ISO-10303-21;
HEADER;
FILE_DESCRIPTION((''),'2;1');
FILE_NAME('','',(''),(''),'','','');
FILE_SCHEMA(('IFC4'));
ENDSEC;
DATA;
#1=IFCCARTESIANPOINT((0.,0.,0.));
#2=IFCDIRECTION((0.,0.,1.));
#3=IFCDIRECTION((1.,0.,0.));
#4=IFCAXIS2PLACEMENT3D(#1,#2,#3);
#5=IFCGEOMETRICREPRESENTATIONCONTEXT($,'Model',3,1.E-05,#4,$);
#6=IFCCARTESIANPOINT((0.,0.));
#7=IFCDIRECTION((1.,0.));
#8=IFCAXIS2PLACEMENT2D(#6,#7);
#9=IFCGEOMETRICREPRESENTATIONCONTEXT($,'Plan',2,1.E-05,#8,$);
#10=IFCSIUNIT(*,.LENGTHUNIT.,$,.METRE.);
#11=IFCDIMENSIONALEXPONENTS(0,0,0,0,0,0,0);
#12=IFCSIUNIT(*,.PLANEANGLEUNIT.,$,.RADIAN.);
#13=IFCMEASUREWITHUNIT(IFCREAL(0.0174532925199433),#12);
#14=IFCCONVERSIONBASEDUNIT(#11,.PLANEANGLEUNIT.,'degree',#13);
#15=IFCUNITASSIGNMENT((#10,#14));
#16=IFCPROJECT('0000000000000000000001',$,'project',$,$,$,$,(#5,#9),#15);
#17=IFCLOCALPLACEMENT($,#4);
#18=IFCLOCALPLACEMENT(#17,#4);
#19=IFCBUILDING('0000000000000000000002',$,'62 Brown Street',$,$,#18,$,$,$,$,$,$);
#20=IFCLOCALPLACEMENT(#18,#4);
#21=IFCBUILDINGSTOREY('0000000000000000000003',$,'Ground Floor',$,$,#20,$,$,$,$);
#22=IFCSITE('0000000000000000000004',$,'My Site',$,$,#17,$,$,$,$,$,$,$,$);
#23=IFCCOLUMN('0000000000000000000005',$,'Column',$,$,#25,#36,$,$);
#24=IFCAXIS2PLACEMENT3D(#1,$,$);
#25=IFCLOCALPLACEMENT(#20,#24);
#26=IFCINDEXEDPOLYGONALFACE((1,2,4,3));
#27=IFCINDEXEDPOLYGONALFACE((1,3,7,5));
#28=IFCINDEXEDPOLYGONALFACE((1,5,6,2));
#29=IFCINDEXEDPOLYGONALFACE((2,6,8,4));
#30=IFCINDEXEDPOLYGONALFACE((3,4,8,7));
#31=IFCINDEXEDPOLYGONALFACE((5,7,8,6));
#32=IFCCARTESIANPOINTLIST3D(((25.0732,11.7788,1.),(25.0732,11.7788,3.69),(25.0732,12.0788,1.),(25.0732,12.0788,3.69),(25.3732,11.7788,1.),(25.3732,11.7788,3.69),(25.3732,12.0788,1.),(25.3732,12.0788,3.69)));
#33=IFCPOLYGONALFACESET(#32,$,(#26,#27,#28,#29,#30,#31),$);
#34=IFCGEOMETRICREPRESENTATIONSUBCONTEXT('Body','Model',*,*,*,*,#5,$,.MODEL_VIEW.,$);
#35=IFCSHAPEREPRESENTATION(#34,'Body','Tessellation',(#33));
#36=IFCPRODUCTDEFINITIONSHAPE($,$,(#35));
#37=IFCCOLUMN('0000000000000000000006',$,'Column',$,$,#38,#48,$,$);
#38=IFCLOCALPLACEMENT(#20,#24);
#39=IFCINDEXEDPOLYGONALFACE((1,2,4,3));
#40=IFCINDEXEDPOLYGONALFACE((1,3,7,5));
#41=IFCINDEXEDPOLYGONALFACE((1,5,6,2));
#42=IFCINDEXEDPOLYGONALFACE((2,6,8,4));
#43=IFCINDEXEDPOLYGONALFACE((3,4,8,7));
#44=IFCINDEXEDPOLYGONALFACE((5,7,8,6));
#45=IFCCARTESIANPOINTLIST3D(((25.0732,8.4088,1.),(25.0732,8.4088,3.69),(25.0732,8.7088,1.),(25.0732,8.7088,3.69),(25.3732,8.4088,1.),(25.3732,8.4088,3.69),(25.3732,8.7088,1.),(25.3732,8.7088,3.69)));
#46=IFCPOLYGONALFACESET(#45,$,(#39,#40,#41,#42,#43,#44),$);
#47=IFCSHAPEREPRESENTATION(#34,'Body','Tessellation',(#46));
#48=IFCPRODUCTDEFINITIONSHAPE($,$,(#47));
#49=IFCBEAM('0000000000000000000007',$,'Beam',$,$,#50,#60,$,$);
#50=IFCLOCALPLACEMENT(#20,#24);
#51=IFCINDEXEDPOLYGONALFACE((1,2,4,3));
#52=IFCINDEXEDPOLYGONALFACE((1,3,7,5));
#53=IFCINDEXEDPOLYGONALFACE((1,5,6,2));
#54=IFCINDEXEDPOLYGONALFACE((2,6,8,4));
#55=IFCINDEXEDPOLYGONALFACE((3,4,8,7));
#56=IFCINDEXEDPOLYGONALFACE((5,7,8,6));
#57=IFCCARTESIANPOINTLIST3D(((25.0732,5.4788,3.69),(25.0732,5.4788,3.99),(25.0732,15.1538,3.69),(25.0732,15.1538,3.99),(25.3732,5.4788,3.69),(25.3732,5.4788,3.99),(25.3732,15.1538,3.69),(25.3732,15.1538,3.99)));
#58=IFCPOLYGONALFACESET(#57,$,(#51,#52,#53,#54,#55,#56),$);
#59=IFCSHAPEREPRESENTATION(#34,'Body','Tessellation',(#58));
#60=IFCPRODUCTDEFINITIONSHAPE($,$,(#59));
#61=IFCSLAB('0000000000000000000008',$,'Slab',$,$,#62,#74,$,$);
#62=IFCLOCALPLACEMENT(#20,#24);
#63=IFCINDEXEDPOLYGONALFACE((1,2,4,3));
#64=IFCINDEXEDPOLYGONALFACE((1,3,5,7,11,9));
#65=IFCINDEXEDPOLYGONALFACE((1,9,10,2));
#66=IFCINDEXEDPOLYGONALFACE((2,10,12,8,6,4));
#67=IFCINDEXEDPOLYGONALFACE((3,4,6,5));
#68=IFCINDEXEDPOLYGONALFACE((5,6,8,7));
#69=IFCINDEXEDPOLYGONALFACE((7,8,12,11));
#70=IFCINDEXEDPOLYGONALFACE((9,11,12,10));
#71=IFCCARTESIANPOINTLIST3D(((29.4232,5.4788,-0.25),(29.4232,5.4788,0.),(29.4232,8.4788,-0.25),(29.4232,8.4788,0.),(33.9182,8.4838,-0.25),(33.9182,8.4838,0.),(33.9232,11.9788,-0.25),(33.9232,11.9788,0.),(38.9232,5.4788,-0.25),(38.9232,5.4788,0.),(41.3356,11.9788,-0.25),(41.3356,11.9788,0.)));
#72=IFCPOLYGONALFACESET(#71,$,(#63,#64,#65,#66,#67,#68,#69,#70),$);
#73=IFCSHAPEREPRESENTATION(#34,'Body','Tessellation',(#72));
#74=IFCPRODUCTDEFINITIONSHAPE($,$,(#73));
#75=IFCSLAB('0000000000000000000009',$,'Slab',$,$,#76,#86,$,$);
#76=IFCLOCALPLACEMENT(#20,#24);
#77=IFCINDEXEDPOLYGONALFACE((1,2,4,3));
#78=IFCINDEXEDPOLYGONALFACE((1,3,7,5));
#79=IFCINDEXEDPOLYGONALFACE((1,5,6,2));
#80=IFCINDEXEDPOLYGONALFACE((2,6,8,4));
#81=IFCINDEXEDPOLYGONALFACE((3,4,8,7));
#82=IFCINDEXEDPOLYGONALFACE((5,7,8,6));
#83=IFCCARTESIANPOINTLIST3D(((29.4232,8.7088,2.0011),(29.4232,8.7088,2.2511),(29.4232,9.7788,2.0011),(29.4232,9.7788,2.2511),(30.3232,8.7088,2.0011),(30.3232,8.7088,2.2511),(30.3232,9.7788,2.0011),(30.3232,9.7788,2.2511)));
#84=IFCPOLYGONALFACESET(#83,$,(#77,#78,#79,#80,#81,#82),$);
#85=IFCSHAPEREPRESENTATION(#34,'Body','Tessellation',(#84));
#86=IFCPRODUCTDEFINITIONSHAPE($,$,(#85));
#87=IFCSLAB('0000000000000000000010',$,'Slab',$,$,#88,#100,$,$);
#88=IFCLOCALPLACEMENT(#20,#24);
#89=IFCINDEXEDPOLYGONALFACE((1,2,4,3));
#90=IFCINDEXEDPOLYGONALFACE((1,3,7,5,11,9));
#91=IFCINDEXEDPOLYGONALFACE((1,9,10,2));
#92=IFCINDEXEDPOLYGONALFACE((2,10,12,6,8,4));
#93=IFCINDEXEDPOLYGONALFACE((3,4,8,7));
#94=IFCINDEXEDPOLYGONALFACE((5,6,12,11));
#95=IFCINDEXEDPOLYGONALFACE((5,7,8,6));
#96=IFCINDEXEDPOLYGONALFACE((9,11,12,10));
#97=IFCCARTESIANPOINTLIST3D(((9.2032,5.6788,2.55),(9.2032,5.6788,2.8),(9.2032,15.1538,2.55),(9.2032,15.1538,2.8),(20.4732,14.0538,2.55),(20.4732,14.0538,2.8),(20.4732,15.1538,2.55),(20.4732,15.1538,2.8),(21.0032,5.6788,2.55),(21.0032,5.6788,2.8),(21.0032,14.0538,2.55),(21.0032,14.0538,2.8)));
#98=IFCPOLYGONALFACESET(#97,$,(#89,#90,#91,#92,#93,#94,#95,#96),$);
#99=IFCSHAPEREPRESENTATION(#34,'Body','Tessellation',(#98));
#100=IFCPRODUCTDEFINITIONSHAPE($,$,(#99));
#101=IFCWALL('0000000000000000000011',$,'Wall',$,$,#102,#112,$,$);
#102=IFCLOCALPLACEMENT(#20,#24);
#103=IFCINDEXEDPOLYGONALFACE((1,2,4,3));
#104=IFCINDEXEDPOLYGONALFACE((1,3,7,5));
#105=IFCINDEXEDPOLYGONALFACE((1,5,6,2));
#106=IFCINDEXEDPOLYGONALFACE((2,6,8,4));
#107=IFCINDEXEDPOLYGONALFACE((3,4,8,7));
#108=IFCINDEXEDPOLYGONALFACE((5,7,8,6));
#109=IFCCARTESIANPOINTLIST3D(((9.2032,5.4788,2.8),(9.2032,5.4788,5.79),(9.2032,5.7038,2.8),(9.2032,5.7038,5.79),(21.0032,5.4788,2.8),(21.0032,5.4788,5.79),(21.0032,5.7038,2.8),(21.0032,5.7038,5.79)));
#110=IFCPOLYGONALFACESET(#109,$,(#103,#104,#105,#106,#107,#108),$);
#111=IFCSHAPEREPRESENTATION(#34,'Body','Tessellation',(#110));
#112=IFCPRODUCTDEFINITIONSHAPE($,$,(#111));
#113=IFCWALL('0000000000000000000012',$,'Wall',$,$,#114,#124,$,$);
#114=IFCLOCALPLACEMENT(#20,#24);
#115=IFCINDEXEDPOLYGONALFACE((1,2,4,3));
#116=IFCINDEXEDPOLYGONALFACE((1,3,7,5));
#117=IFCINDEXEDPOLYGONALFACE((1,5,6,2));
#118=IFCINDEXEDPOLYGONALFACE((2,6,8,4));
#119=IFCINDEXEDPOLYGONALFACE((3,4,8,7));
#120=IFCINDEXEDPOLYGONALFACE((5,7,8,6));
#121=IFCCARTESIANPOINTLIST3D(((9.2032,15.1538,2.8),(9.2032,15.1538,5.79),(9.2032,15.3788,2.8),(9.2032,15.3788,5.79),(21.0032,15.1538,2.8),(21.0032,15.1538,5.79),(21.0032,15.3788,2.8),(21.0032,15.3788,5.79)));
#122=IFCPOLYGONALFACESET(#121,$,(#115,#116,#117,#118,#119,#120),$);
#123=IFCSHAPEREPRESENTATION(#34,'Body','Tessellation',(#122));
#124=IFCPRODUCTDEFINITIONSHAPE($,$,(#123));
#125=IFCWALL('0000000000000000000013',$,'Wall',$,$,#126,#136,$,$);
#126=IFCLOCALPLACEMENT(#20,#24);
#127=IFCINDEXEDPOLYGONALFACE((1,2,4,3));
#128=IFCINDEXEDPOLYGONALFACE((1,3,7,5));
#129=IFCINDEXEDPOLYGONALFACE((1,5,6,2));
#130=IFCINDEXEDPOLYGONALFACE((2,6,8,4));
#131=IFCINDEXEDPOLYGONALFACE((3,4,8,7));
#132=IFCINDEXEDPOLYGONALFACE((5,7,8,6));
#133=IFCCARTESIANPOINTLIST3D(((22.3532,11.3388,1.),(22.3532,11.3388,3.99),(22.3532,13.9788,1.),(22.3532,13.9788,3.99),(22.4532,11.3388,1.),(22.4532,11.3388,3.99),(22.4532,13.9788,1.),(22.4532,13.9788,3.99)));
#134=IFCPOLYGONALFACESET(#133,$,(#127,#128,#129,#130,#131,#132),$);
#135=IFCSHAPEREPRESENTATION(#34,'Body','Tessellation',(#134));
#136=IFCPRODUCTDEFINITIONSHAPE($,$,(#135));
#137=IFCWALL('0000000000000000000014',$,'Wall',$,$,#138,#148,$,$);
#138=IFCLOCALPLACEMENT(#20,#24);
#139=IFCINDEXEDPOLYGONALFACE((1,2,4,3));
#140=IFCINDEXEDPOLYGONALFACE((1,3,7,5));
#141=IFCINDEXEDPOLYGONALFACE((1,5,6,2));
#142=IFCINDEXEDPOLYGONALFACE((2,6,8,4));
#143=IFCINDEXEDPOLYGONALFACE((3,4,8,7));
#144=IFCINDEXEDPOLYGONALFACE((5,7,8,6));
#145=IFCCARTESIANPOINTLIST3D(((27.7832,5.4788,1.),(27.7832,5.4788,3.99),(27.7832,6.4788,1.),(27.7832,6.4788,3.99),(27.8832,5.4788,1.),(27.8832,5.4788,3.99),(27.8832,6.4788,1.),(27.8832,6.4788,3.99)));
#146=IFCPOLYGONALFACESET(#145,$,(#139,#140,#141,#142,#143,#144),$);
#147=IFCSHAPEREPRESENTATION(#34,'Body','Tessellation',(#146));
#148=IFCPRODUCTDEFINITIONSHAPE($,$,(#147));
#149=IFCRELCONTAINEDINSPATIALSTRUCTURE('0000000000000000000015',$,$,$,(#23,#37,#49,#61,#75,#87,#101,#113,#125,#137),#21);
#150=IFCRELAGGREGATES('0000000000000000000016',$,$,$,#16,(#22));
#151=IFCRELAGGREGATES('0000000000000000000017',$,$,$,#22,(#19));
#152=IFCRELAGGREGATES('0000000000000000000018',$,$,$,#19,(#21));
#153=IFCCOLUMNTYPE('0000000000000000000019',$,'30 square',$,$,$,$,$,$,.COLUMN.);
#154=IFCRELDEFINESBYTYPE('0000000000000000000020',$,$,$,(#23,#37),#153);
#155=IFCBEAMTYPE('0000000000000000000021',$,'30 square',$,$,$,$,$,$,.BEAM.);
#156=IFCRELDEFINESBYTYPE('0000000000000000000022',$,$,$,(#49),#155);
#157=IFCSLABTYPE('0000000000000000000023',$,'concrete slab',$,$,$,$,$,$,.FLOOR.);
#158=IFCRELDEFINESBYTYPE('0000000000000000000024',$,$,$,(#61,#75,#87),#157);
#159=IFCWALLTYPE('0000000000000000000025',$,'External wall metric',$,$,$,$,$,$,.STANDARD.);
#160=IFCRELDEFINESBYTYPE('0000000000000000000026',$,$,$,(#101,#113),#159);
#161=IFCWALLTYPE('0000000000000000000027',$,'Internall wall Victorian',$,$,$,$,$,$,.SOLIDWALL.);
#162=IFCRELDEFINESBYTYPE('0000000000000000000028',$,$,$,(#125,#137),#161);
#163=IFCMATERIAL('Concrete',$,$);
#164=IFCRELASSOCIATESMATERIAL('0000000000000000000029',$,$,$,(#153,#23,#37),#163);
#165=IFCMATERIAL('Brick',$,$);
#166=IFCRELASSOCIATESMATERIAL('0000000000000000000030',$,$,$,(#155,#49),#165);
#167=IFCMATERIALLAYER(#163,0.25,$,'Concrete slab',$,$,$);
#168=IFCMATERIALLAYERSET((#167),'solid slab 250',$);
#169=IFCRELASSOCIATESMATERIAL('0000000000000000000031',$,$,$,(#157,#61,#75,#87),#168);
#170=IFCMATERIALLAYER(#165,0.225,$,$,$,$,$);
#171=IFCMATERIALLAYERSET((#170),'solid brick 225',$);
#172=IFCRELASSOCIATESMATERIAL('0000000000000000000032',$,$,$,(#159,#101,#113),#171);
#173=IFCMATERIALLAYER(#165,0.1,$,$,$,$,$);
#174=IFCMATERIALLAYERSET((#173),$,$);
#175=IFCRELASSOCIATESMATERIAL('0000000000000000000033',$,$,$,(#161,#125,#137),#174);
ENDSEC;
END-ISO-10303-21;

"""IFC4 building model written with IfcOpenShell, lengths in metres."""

from ifc_helpers import new_model, entity, si_unit, converted_unit, frame, origin_with_axes, origin_2d_with_axis, place, context, subcontext, project, spatial, line, indexed_curve, rectangle, outline, extrude, material, layer, layer_set, layer_usage, material_profile, profile_set, profile_usage, type_object, element, save


model = new_model("IFC4")

# Units and contexts
model_context = context("Model", 3, precision=1e-05, world=origin_with_axes())
plan_context = context("Plan", 2, precision=1e-05, world=origin_2d_with_axis())
body_context_1 = subcontext(model_context, "Body", "Model", "MODEL_VIEW")
ifc_project = project(units=[si_unit("LENGTHUNIT", "METRE"), converted_unit("PLANEANGLEUNIT", "degree", entity("IfcReal", 0.0174532925199433), si_unit("PLANEANGLEUNIT", "RADIAN"), dimensions=[0, 0, 0, 0, 0, 0, 0])], contexts=[model_context, plan_context])

# Site, building, storey
site_placement = place(None, origin_with_axes())
site = spatial("IfcSite", under=ifc_project, at=site_placement, Name="My Site")
building_placement = place(site_placement, origin_with_axes())
building = spatial("IfcBuilding", under=site, at=building_placement, Name="62 Brown Street")
storey_placement = place(building_placement, origin_with_axes())
storey = spatial("IfcBuildingStorey", under=building, at=storey_placement, Name="Ground Floor")

# Columns
ifc_material_1 = material(Name="Concrete")
ifc_material_profile_1 = material_profile(ifc_material_1, rectangle(XDim=0.3, YDim=0.3))
ifc_profile_set_1 = profile_set([ifc_material_profile_1])
ifc_profile_usage_1 = profile_usage(ifc_profile_set_1, cardinal=5)
column_type = type_object("IfcColumnType", Name="30 square", PredefinedType="COLUMN", material=ifc_profile_set_1)
column_1_placement = place(storey_placement, frame((25.2232, 11.9288, 1.0), z_axis=(0.0, 0.0, 1.0), x_axis=(1.0, 0.0, 0.0)))
element("IfcColumn", 1, at=column_1_placement, inside=storey, type_object=column_type, material=ifc_profile_usage_1, Name="Column", context=body_context_1, shape_type="SweptSolid", body=[
    extrude(rectangle(XDim=0.3, YDim=0.3), origin_with_axes(), (0.0, 0.0, 1.0), 2.69),
])
ifc_profile_usage_2 = profile_usage(ifc_profile_set_1, cardinal=5)
column_2_placement = place(storey_placement, frame((25.2232, 8.5588, 1.0), z_axis=(0.0, 0.0, 1.0), x_axis=(1.0, 0.0, 0.0)))
element("IfcColumn", 2, at=column_2_placement, inside=storey, type_object=column_type, material=ifc_profile_usage_2, Name="Column", context=body_context_1, shape_type="SweptSolid", body=[
    extrude(rectangle(XDim=0.3, YDim=0.3), origin_with_axes(), (0.0, 0.0, 1.0), 2.69),
])

# Beam
ifc_material_2 = material(Name="Brick")
ifc_material_profile_2 = material_profile(ifc_material_2, rectangle(XDim=0.3, YDim=0.3))
ifc_profile_set_2 = profile_set([ifc_material_profile_2])
ifc_profile_usage_3 = profile_usage(ifc_profile_set_2, cardinal=5)
beam_type = type_object("IfcBeamType", Name="30 square", PredefinedType="BEAM", material=ifc_profile_set_2)
beam_placement = place(storey_placement, frame((25.2232, 5.4788, 3.84), z_axis=(0.0, 1.0, 0.0), x_axis=(-1.0, 0.0, 0.0)))
element("IfcBeam", 3, at=beam_placement, inside=storey, type_object=beam_type, material=ifc_profile_usage_3, Name="Beam", context=body_context_1, shape_type="SweptSolid", body=[
    extrude(rectangle(XDim=0.3, YDim=0.3), origin_with_axes(), (0.0, 0.0, 1.0), 9.675),
])

# Slabs
ifc_layer_1 = layer(ifc_material_1, 0.25, Name="Concrete slab")
ifc_layer_set_1 = layer_set([ifc_layer_1], Name="solid slab 250")
ifc_layer_usage_1 = layer_usage(ifc_layer_set_1, "AXIS3", "POSITIVE", 0.0)
slab_type = type_object("IfcSlabType", Name="concrete slab", PredefinedType="FLOOR", material=ifc_layer_set_1)
slab_1_placement = place(storey_placement, frame((29.4232, 5.4788, -0.25), z_axis=(0.0, 0.0, 1.0), x_axis=(1.0, 0.0, 0.0)))
element("IfcSlab", 4, at=slab_1_placement, inside=storey, type_object=slab_type, material=ifc_layer_usage_1, Name="Slab", context=body_context_1, shape_type="SweptSolid", body=[
    extrude(outline(indexed_curve([(0.0, 0.0), (9.5, 0.0), (11.9124, 6.5), (0.0, 3.0), (4.5, 6.5), (4.495, 3.005)], segments=[line(1, 2), line(2, 3), line(3, 5), line(5, 6), line(6, 4), line(4, 1)], self_intersect=False)), None, (0.0, 0.0, 1.0), 0.25),
])
ifc_layer_usage_2 = layer_usage(ifc_layer_set_1, "AXIS3", "POSITIVE", 0.0)
slab_2_placement = place(storey_placement, frame((29.4232, 8.7088, 2.0011), z_axis=(0.0, 0.0, 1.0), x_axis=(1.0, 0.0, 0.0)))
element("IfcSlab", 5, at=slab_2_placement, inside=storey, type_object=slab_type, material=ifc_layer_usage_2, Name="Slab", context=body_context_1, shape_type="SweptSolid", body=[
    extrude(outline(indexed_curve([(0.9, 1.07), (0.9, 0.0), (0.0, 0.0), (0.0, 1.07)], segments=[line(3, 2), line(2, 1), line(1, 4), line(4, 3)], self_intersect=False)), None, (0.0, 0.0, 1.0), 0.25),
])
ifc_layer_usage_3 = layer_usage(ifc_layer_set_1, "AXIS3", "POSITIVE", 0.0)
slab_3_placement = place(storey_placement, frame((9.2032, 5.6788, 2.55), z_axis=(0.0, 0.0, 1.0), x_axis=(1.0, 0.0, 0.0)))
element("IfcSlab", 6, at=slab_3_placement, inside=storey, type_object=slab_type, material=ifc_layer_usage_3, Name="Slab", context=body_context_1, shape_type="SweptSolid", body=[
    extrude(outline(indexed_curve([(11.27, 9.475), (11.8, 0.0), (0.0, 0.0), (0.0, 9.475), (11.8, 8.375), (11.27, 8.375)], segments=[line(6, 1), line(1, 4), line(4, 3), line(3, 2), line(2, 5), line(5, 6)], self_intersect=False)), None, (0.0, 0.0, 1.0), 0.25),
])

# Walls
ifc_layer_2 = layer(ifc_material_2, 0.225)
ifc_layer_set_2 = layer_set([ifc_layer_2], Name="solid brick 225")
wall_type_1 = type_object("IfcWallType", Name="External wall metric", PredefinedType="STANDARD", material=ifc_layer_set_2)
ifc_layer_usage_4 = layer_usage(ifc_layer_set_2, "AXIS2", "POSITIVE", 0.0)
wall_1_placement = place(storey_placement, frame((9.2032, 5.4788, 2.8), z_axis=(0.0, 0.0, 1.0), x_axis=(1.0, 0.0, 0.0)))
element("IfcWall", 7, at=wall_1_placement, inside=storey, type_object=wall_type_1, material=ifc_layer_usage_4, Name="Wall", context=body_context_1, shape_type="SweptSolid", body=[
    extrude(outline(indexed_curve([(0.0, 0.0), (0.0, 0.225), (11.8, 0.225), (11.8, 0.0), (0.0, 0.0)], self_intersect=False)), origin_with_axes(), (0.0, 0.0, 1.0), 2.99),
])
ifc_layer_usage_5 = layer_usage(ifc_layer_set_2, "AXIS2", "POSITIVE", 0.0)
wall_2_placement = place(storey_placement, frame((21.0032, 15.3788, 2.8), z_axis=(0.0, 0.0, 1.0), x_axis=(-1.0, 0.0, 0.0)))
element("IfcWall", 8, at=wall_2_placement, inside=storey, type_object=wall_type_1, material=ifc_layer_usage_5, Name="Wall", context=body_context_1, shape_type="SweptSolid", body=[
    extrude(outline(indexed_curve([(0.0, 0.0), (0.0, 0.225), (11.8, 0.225), (11.8, 0.0), (0.0, 0.0)], self_intersect=False)), origin_with_axes(), (0.0, 0.0, 1.0), 2.99),
])

# Walls
ifc_layer_3 = layer(ifc_material_2, 0.1)
ifc_layer_set_3 = layer_set([ifc_layer_3])
ifc_layer_usage_6 = layer_usage(ifc_layer_set_3, "AXIS2", "POSITIVE", 0.0)
wall_type_2 = type_object("IfcWallType", Name="Internall wall Victorian", PredefinedType="SOLIDWALL", material=ifc_layer_set_3)
wall_3_placement = place(storey_placement, frame((22.4532, 11.3388, 1.0), z_axis=(0.0, 0.0, 1.0), x_axis=(0.0, 1.0, 0.0)))
element("IfcWall", 9, at=wall_3_placement, inside=storey, type_object=wall_type_2, material=ifc_layer_usage_6, Name="Wall", context=body_context_1, shape_type="SweptSolid", body=[
    extrude(outline(indexed_curve([(0.0, 0.0), (0.0, 0.1), (2.64, 0.1), (2.64, 0.0), (0.0, 0.0)], self_intersect=False)), origin_with_axes(), (0.0, 0.0, 1.0), 2.99),
])
ifc_layer_usage_7 = layer_usage(ifc_layer_set_3, "AXIS2", "POSITIVE", 0.0)
wall_4_placement = place(storey_placement, frame((27.8832, 5.4788, 1.0), z_axis=(0.0, 0.0, 1.0), x_axis=(0.0, 1.0, 0.0)))
element("IfcWall", 10, at=wall_4_placement, inside=storey, type_object=wall_type_2, material=ifc_layer_usage_7, Name="Wall", context=body_context_1, shape_type="SweptSolid", body=[
    extrude(outline(indexed_curve([(0.0, 0.0), (0.0, 0.1), (1.0, 0.1), (1.0, 0.0), (0.0, 0.0)], self_intersect=False)), origin_with_axes(), (0.0, 0.0, 1.0), 2.99),
])

save(model, "model.ifc")
